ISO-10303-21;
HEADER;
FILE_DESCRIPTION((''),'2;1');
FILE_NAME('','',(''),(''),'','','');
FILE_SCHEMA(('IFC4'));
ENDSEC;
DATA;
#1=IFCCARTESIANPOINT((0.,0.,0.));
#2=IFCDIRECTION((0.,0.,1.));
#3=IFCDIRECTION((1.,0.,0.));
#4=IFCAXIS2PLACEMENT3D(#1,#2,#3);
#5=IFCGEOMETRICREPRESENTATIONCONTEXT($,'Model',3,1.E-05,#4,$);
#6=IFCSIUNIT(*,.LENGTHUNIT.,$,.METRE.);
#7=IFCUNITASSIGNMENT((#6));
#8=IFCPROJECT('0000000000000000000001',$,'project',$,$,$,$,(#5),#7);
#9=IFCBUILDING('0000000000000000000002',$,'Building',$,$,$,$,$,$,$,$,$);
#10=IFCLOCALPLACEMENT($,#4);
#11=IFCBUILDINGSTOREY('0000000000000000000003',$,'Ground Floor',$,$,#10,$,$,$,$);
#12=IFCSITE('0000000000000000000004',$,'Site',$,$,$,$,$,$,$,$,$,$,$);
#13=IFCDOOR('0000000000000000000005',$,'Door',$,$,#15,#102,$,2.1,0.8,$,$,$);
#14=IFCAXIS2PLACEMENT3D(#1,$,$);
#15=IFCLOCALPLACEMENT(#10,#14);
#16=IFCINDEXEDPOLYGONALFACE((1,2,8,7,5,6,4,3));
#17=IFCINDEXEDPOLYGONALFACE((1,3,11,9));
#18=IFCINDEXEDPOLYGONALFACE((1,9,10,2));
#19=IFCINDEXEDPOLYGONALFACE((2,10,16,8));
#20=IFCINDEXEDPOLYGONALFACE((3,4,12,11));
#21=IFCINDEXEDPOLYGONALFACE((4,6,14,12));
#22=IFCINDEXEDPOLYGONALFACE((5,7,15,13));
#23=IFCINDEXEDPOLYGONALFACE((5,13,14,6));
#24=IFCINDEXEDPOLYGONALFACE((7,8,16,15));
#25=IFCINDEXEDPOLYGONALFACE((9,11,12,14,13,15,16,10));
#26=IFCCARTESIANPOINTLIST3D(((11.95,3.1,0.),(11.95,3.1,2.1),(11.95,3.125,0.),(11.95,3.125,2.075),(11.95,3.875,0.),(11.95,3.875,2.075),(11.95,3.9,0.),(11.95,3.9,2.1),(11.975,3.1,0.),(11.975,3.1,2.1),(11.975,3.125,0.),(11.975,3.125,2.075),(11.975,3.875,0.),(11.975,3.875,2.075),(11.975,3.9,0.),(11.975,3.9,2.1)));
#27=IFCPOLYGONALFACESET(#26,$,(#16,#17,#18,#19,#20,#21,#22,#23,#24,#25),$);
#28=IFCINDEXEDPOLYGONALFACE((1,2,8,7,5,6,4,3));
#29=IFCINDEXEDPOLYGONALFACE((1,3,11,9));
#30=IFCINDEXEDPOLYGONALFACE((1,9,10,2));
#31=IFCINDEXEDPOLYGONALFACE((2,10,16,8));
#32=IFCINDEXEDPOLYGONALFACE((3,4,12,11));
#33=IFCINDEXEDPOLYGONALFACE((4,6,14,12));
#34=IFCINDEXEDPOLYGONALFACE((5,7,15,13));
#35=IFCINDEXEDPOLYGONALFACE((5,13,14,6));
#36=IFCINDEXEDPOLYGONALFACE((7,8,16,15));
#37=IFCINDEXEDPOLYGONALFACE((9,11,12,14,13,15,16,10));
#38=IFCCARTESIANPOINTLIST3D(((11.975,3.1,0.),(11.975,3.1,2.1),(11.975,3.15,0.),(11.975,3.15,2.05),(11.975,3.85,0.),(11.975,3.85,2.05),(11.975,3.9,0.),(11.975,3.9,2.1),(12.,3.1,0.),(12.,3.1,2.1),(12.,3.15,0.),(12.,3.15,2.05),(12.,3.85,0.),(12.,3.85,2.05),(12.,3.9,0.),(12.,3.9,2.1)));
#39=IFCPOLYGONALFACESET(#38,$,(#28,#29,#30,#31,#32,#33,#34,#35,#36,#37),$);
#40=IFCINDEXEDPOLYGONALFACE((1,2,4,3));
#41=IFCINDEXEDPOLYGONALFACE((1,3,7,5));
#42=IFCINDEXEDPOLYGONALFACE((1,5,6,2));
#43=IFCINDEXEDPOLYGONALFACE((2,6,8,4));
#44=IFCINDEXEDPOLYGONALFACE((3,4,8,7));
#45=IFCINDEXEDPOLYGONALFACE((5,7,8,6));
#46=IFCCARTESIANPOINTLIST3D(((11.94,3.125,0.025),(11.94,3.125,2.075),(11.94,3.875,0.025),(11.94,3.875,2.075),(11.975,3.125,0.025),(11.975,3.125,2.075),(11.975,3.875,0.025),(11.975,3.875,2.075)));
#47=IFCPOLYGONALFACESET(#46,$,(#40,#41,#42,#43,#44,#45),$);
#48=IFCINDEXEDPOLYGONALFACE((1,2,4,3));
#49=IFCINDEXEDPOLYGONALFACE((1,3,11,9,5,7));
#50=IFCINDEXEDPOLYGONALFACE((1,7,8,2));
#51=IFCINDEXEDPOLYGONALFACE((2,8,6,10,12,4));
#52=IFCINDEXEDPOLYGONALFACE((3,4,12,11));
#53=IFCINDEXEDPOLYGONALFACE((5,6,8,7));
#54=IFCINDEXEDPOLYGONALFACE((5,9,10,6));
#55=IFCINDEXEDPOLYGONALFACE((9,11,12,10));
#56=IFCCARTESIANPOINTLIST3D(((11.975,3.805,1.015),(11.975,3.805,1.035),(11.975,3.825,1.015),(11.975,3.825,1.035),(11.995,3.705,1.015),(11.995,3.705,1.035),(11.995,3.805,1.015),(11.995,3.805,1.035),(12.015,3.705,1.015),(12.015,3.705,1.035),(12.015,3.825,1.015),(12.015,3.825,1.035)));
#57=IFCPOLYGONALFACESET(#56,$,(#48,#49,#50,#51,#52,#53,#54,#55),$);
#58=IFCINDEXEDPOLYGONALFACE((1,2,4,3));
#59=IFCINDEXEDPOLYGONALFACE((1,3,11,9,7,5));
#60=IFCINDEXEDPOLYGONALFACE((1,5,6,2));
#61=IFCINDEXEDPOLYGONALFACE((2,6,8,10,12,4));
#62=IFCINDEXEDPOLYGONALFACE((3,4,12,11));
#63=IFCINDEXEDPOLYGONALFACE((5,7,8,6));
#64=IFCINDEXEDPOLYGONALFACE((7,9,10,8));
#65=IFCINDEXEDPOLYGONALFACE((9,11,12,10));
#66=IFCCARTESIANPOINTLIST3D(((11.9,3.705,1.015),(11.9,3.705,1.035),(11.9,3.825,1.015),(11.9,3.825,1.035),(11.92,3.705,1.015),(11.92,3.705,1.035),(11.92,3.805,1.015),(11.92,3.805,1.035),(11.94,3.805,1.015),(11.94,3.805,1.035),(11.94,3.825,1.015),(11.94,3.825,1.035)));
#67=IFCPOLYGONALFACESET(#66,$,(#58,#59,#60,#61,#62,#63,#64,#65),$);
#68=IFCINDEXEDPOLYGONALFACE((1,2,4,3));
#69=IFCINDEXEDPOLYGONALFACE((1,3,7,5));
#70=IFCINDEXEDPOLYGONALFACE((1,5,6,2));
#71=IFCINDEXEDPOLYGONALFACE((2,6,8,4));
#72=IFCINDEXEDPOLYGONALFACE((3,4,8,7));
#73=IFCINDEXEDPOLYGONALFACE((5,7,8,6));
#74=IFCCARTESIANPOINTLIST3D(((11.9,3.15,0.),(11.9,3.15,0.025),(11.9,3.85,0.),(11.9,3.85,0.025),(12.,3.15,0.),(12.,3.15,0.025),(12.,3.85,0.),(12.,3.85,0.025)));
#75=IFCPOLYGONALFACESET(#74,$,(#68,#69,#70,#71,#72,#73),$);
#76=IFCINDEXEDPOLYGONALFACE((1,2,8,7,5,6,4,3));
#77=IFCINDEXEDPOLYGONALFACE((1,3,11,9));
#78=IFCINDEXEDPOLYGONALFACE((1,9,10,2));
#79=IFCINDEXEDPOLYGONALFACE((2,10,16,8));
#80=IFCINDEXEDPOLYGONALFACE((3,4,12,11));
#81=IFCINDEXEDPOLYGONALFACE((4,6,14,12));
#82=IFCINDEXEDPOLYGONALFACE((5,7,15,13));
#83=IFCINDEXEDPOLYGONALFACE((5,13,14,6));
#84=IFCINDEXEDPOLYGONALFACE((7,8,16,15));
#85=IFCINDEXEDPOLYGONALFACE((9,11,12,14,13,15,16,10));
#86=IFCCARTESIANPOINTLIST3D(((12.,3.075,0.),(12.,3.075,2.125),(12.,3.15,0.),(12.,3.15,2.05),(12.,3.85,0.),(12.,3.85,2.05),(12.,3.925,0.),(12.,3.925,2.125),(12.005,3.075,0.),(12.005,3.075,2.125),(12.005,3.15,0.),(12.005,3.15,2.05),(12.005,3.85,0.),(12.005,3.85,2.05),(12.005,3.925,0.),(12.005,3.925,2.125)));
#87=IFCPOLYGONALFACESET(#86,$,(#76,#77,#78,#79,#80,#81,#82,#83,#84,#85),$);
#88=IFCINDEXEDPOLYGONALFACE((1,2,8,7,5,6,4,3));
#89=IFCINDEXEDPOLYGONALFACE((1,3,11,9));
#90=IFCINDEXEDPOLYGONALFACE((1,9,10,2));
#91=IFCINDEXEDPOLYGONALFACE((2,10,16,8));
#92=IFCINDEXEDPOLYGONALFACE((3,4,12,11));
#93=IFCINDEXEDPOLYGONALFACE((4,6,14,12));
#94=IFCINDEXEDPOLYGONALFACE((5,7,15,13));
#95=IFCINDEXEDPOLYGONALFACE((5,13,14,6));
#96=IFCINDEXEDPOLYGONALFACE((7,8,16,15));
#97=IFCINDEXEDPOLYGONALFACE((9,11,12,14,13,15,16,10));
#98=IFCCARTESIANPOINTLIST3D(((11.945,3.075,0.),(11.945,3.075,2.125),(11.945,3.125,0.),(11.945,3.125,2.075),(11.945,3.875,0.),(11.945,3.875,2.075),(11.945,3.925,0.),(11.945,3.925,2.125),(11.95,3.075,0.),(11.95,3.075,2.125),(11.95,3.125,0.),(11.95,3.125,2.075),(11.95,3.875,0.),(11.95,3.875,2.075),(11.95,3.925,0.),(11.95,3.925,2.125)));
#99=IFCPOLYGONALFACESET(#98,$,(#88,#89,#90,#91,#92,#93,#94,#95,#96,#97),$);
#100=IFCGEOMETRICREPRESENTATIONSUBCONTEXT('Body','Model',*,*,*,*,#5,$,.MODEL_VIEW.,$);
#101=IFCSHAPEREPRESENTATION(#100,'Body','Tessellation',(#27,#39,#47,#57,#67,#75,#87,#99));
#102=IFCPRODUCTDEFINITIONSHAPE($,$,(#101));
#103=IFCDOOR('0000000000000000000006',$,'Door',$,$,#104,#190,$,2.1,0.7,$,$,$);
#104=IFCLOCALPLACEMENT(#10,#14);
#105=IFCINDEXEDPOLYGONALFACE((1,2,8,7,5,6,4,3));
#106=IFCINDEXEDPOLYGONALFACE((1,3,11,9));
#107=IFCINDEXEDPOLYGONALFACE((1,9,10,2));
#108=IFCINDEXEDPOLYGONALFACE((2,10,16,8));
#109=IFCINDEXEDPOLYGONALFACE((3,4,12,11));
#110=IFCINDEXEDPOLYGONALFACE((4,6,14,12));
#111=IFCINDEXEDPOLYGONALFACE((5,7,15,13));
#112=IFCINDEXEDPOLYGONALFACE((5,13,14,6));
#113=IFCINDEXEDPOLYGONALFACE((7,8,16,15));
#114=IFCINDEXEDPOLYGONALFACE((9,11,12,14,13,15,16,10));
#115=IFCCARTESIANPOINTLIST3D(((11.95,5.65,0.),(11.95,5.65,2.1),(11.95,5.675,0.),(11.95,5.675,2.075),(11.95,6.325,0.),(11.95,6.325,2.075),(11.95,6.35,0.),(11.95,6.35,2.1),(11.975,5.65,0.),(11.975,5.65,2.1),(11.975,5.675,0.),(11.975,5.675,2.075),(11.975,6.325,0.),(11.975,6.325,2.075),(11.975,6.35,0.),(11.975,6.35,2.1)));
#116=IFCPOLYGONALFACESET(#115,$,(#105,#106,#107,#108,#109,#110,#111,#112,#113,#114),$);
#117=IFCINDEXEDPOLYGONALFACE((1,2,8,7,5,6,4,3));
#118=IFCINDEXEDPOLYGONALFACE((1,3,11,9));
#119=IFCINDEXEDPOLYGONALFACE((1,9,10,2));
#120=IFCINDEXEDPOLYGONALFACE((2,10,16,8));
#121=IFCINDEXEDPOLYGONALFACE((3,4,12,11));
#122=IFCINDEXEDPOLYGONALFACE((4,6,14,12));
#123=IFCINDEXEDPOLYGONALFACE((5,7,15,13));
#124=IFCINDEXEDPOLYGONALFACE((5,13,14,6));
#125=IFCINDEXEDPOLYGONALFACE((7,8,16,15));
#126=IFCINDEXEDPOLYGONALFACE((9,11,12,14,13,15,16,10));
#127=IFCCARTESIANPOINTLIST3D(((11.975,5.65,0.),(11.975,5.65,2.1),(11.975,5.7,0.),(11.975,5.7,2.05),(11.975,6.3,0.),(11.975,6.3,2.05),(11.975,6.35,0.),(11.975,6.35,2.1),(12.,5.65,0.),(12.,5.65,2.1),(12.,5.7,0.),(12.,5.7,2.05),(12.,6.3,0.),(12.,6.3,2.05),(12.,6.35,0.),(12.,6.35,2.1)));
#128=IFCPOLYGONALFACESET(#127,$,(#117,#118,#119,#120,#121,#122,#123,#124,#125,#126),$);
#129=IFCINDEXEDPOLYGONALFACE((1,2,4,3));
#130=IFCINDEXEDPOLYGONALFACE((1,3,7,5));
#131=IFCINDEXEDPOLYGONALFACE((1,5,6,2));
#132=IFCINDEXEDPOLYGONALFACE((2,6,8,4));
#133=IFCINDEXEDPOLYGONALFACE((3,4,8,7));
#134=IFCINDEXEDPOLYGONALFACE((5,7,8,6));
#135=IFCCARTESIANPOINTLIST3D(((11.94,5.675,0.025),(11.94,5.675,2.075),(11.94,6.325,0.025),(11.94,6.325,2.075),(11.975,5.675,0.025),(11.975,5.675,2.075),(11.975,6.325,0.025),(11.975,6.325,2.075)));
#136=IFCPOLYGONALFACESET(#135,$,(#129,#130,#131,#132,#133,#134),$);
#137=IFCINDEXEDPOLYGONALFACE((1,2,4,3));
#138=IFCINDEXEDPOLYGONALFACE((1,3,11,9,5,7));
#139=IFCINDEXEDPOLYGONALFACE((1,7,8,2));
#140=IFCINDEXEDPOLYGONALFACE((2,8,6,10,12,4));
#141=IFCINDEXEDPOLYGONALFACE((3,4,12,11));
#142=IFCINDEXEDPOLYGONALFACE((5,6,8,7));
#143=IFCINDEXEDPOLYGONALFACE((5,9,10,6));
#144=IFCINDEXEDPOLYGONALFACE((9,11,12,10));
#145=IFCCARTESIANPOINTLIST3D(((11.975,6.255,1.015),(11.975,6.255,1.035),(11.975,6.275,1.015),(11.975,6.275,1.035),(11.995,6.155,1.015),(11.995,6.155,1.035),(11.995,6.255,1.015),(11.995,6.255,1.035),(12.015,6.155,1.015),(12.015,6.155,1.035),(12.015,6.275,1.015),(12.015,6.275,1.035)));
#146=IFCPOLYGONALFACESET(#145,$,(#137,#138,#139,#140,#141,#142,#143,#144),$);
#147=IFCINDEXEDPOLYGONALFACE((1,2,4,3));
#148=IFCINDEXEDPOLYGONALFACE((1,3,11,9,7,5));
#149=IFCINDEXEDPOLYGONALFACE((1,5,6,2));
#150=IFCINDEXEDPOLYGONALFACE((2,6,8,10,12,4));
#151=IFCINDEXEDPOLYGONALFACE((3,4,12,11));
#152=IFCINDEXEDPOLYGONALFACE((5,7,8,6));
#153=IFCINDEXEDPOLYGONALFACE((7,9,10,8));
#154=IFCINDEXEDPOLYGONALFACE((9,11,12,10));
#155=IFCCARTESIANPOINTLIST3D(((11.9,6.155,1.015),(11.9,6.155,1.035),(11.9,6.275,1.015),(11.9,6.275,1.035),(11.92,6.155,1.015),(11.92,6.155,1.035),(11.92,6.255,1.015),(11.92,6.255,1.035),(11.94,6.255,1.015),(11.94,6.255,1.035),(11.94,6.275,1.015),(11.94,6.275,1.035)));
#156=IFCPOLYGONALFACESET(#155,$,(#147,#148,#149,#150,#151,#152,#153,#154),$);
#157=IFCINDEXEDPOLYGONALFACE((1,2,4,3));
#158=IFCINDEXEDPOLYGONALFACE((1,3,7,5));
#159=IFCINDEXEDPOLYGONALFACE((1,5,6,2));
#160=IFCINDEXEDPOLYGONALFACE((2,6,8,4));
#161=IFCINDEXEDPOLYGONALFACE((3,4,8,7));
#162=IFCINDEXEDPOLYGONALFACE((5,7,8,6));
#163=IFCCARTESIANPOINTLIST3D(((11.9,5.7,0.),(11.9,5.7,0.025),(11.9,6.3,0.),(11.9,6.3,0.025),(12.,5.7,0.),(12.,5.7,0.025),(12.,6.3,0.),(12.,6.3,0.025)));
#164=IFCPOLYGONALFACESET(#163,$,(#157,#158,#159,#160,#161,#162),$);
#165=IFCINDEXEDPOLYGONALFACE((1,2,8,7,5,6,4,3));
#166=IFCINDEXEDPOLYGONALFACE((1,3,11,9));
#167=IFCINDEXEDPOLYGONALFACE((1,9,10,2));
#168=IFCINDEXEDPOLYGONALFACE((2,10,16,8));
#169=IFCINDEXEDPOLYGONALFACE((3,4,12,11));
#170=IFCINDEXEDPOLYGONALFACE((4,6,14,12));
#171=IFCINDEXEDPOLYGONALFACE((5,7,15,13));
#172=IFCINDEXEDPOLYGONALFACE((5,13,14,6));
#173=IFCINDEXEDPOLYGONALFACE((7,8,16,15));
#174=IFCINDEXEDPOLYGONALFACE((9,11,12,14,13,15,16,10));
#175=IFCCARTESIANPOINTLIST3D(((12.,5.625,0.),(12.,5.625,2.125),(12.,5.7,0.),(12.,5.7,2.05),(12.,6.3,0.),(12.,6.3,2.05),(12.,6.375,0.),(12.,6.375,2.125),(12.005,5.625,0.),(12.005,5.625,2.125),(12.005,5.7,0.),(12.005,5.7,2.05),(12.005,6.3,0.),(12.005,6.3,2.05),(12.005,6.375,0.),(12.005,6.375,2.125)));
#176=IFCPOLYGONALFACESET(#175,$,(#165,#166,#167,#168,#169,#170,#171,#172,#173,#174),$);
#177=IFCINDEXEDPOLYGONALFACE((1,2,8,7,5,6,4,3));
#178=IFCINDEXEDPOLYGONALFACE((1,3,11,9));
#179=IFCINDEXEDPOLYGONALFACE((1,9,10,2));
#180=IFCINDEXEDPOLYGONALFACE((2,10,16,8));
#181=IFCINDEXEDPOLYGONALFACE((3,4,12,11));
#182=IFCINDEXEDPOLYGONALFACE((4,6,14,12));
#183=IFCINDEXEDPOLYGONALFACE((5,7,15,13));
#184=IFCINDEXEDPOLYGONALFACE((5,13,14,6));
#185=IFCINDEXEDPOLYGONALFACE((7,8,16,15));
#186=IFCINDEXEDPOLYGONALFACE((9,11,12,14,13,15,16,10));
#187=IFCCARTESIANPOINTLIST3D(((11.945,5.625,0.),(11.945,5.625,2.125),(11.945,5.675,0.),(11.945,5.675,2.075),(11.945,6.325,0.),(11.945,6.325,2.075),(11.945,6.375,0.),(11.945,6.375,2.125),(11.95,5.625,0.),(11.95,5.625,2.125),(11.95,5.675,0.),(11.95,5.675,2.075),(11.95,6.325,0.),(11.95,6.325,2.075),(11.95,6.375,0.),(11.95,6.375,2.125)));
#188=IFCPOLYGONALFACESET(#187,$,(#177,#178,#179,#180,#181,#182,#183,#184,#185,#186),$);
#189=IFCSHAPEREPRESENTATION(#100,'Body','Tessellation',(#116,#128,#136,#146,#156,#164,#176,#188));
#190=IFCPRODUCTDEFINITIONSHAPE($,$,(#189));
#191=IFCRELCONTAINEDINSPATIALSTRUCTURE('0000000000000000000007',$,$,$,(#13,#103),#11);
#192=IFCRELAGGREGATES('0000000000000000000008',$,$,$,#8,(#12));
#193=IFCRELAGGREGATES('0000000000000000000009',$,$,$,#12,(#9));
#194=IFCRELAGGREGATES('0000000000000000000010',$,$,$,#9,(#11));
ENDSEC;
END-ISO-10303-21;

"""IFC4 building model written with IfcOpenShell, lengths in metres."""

from ifc_helpers import new_model, si_unit, frame, origin_with_axes, place, context, subcontext, project, spatial, line, indexed_curve, outline, extrude, element, save


model = new_model("IFC4")

# Units and contexts
model_context = context("Model", 3, precision=1e-05, world=origin_with_axes())
body_context = subcontext(model_context, "Body", "Model", "MODEL_VIEW")
ifc_project = project(units=[si_unit("LENGTHUNIT", "METRE")], contexts=[model_context])

# Site, building, storey
site = spatial("IfcSite", under=ifc_project, Name="Site")
building = spatial("IfcBuilding", under=site, Name="Building")
storey_placement = place(None, origin_with_axes())
storey = spatial("IfcBuildingStorey", under=building, at=storey_placement, Name="Ground Floor")

# Doors
door_1_placement = place(storey_placement, frame((12.0, 3.1, 0.0), z_axis=(0.0, 0.0, 1.0), x_axis=(0.0, 1.0, 0.0)))
element("IfcDoor", 1, at=door_1_placement, inside=storey, Name="Door", OverallHeight=2.1, OverallWidth=0.8, context=body_context, shape_type="SweptSolid", body=[
    extrude(outline(indexed_curve([(0.0, 0.0), (0.0, 2.1), (0.8, 2.1), (0.8, 0.0), (0.775, 0.0), (0.775, 2.075), (0.025, 2.075), (0.025, 0.0)], segments=[line(1, 2, 3, 4, 5, 6, 7, 8, 1)])), frame((0.0, 0.025, 0.0), z_axis=(0.0, -1.0, 0.0), x_axis=(1.0, 0.0, 0.0)), (0.0, 0.0, -1.0), 0.025),
    extrude(outline(indexed_curve([(0.0, 0.0), (0.0, 2.1), (0.8, 2.1), (0.8, 0.0), (0.75, 0.0), (0.75, 2.05), (0.05, 2.05), (0.05, 0.0)], segments=[line(1, 2, 3, 4, 5, 6, 7, 8, 1)])), frame((0.0, 0.0, 0.0), z_axis=(0.0, -1.0, 0.0), x_axis=(1.0, 0.0, 0.0)), (0.0, 0.0, -1.0), 0.025),
    extrude(outline(indexed_curve([(0.0, 0.0), (0.75, 0.0), (0.75, 0.035), (0.0, 0.035)], segments=[line(1, 2, 3, 4, 1)])), frame((0.025, 0.025, 0.025), z_axis=(0.0, 0.0, 1.0), x_axis=(1.0, 0.0, 0.0)), (0.0, 0.0, 1.0), 2.05),
    extrude(outline(indexed_curve([(0.0, 0.0), (0.0, -0.04), (-0.12, -0.04), (-0.12, -0.02), (-0.02, -0.02), (-0.02, 0.0)], segments=[line(1, 2, 3, 4, 5, 6, 1)])), frame((0.725, 0.025, 1.015), z_axis=(0.0, 0.0, 1.0), x_axis=(1.0, 0.0, 0.0)), (0.0, 0.0, 1.0), 0.02),
    extrude(outline(indexed_curve([(0.0, 0.0), (0.0, 0.04), (-0.12, 0.04), (-0.12, 0.02), (-0.02, 0.02), (-0.02, 0.0)], segments=[line(1, 2, 3, 4, 5, 6, 1)])), frame((0.725, 0.06, 1.015), z_axis=(0.0, 0.0, 1.0), x_axis=(1.0, 0.0, 0.0)), (0.0, 0.0, 1.0), 0.02),
    extrude(outline(indexed_curve([(0.0, 0.0), (0.7, 0.0), (0.7, 0.1), (0.0, 0.1)], segments=[line(1, 2, 3, 4, 1)])), frame((0.05, 0.0, 0.0), z_axis=(0.0, 0.0, 1.0), x_axis=(1.0, 0.0, 0.0)), (0.0, 0.0, 1.0), 0.025),
    extrude(outline(indexed_curve([(0.0, 0.0), (0.0, 2.125), (0.85, 2.125), (0.85, 0.0), (0.775, 0.0), (0.775, 2.05), (0.075, 2.05), (0.075, 0.0)], segments=[line(1, 2, 3, 4, 5, 6, 7, 8, 1)])), frame((-0.025, -0.005, 0.0), z_axis=(0.0, -1.0, 0.0), x_axis=(1.0, 0.0, 0.0)), (0.0, 0.0, -1.0), 0.005),
    extrude(outline(indexed_curve([(0.0, 0.0), (0.0, 2.125), (0.85, 2.125), (0.85, 0.0), (0.8, 0.0), (0.8, 2.075), (0.05, 2.075), (0.05, 0.0)], segments=[line(1, 2, 3, 4, 5, 6, 7, 8, 1)])), frame((-0.025, 0.05, 0.0), z_axis=(0.0, -1.0, 0.0), x_axis=(1.0, 0.0, 0.0)), (0.0, 0.0, -1.0), 0.005),
])
door_2_placement = place(storey_placement, frame((12.0, 5.65, 0.0), z_axis=(0.0, 0.0, 1.0), x_axis=(0.0, 1.0, 0.0)))
element("IfcDoor", 2, at=door_2_placement, inside=storey, Name="Door", OverallHeight=2.1, OverallWidth=0.7, context=body_context, shape_type="SweptSolid", body=[
    extrude(outline(indexed_curve([(0.0, 0.0), (0.0, 2.1), (0.7, 2.1), (0.7, 0.0), (0.675, 0.0), (0.675, 2.075), (0.025, 2.075), (0.025, 0.0)], segments=[line(1, 2, 3, 4, 5, 6, 7, 8, 1)])), frame((0.0, 0.025, 0.0), z_axis=(0.0, -1.0, 0.0), x_axis=(1.0, 0.0, 0.0)), (0.0, 0.0, -1.0), 0.025),
    extrude(outline(indexed_curve([(0.0, 0.0), (0.0, 2.1), (0.7, 2.1), (0.7, 0.0), (0.65, 0.0), (0.65, 2.05), (0.05, 2.05), (0.05, 0.0)], segments=[line(1, 2, 3, 4, 5, 6, 7, 8, 1)])), frame((0.0, 0.0, 0.0), z_axis=(0.0, -1.0, 0.0), x_axis=(1.0, 0.0, 0.0)), (0.0, 0.0, -1.0), 0.025),
    extrude(outline(indexed_curve([(0.0, 0.0), (0.65, 0.0), (0.65, 0.035), (0.0, 0.035)], segments=[line(1, 2, 3, 4, 1)])), frame((0.025, 0.025, 0.025), z_axis=(0.0, 0.0, 1.0), x_axis=(1.0, 0.0, 0.0)), (0.0, 0.0, 1.0), 2.05),
    extrude(outline(indexed_curve([(0.0, 0.0), (0.0, -0.04), (-0.12, -0.04), (-0.12, -0.02), (-0.02, -0.02), (-0.02, 0.0)], segments=[line(1, 2, 3, 4, 5, 6, 1)])), frame((0.625, 0.025, 1.015), z_axis=(0.0, 0.0, 1.0), x_axis=(1.0, 0.0, 0.0)), (0.0, 0.0, 1.0), 0.02),
    extrude(outline(indexed_curve([(0.0, 0.0), (0.0, 0.04), (-0.12, 0.04), (-0.12, 0.02), (-0.02, 0.02), (-0.02, 0.0)], segments=[line(1, 2, 3, 4, 5, 6, 1)])), frame((0.625, 0.06, 1.015), z_axis=(0.0, 0.0, 1.0), x_axis=(1.0, 0.0, 0.0)), (0.0, 0.0, 1.0), 0.02),
    extrude(outline(indexed_curve([(0.0, 0.0), (0.6, 0.0), (0.6, 0.1), (0.0, 0.1)], segments=[line(1, 2, 3, 4, 1)])), frame((0.05, 0.0, 0.0), z_axis=(0.0, 0.0, 1.0), x_axis=(1.0, 0.0, 0.0)), (0.0, 0.0, 1.0), 0.025),
    extrude(outline(indexed_curve([(0.0, 0.0), (0.0, 2.125), (0.75, 2.125), (0.75, 0.0), (0.675, 0.0), (0.675, 2.05), (0.075, 2.05), (0.075, 0.0)], segments=[line(1, 2, 3, 4, 5, 6, 7, 8, 1)])), frame((-0.025, -0.005, 0.0), z_axis=(0.0, -1.0, 0.0), x_axis=(1.0, 0.0, 0.0)), (0.0, 0.0, -1.0), 0.005),
    extrude(outline(indexed_curve([(0.0, 0.0), (0.0, 2.125), (0.75, 2.125), (0.75, 0.0), (0.7, 0.0), (0.7, 2.075), (0.05, 2.075), (0.05, 0.0)], segments=[line(1, 2, 3, 4, 5, 6, 7, 8, 1)])), frame((-0.025, 0.05, 0.0), z_axis=(0.0, -1.0, 0.0), x_axis=(1.0, 0.0, 0.0)), (0.0, 0.0, -1.0), 0.005),
])

save(model, "model.ifc")
